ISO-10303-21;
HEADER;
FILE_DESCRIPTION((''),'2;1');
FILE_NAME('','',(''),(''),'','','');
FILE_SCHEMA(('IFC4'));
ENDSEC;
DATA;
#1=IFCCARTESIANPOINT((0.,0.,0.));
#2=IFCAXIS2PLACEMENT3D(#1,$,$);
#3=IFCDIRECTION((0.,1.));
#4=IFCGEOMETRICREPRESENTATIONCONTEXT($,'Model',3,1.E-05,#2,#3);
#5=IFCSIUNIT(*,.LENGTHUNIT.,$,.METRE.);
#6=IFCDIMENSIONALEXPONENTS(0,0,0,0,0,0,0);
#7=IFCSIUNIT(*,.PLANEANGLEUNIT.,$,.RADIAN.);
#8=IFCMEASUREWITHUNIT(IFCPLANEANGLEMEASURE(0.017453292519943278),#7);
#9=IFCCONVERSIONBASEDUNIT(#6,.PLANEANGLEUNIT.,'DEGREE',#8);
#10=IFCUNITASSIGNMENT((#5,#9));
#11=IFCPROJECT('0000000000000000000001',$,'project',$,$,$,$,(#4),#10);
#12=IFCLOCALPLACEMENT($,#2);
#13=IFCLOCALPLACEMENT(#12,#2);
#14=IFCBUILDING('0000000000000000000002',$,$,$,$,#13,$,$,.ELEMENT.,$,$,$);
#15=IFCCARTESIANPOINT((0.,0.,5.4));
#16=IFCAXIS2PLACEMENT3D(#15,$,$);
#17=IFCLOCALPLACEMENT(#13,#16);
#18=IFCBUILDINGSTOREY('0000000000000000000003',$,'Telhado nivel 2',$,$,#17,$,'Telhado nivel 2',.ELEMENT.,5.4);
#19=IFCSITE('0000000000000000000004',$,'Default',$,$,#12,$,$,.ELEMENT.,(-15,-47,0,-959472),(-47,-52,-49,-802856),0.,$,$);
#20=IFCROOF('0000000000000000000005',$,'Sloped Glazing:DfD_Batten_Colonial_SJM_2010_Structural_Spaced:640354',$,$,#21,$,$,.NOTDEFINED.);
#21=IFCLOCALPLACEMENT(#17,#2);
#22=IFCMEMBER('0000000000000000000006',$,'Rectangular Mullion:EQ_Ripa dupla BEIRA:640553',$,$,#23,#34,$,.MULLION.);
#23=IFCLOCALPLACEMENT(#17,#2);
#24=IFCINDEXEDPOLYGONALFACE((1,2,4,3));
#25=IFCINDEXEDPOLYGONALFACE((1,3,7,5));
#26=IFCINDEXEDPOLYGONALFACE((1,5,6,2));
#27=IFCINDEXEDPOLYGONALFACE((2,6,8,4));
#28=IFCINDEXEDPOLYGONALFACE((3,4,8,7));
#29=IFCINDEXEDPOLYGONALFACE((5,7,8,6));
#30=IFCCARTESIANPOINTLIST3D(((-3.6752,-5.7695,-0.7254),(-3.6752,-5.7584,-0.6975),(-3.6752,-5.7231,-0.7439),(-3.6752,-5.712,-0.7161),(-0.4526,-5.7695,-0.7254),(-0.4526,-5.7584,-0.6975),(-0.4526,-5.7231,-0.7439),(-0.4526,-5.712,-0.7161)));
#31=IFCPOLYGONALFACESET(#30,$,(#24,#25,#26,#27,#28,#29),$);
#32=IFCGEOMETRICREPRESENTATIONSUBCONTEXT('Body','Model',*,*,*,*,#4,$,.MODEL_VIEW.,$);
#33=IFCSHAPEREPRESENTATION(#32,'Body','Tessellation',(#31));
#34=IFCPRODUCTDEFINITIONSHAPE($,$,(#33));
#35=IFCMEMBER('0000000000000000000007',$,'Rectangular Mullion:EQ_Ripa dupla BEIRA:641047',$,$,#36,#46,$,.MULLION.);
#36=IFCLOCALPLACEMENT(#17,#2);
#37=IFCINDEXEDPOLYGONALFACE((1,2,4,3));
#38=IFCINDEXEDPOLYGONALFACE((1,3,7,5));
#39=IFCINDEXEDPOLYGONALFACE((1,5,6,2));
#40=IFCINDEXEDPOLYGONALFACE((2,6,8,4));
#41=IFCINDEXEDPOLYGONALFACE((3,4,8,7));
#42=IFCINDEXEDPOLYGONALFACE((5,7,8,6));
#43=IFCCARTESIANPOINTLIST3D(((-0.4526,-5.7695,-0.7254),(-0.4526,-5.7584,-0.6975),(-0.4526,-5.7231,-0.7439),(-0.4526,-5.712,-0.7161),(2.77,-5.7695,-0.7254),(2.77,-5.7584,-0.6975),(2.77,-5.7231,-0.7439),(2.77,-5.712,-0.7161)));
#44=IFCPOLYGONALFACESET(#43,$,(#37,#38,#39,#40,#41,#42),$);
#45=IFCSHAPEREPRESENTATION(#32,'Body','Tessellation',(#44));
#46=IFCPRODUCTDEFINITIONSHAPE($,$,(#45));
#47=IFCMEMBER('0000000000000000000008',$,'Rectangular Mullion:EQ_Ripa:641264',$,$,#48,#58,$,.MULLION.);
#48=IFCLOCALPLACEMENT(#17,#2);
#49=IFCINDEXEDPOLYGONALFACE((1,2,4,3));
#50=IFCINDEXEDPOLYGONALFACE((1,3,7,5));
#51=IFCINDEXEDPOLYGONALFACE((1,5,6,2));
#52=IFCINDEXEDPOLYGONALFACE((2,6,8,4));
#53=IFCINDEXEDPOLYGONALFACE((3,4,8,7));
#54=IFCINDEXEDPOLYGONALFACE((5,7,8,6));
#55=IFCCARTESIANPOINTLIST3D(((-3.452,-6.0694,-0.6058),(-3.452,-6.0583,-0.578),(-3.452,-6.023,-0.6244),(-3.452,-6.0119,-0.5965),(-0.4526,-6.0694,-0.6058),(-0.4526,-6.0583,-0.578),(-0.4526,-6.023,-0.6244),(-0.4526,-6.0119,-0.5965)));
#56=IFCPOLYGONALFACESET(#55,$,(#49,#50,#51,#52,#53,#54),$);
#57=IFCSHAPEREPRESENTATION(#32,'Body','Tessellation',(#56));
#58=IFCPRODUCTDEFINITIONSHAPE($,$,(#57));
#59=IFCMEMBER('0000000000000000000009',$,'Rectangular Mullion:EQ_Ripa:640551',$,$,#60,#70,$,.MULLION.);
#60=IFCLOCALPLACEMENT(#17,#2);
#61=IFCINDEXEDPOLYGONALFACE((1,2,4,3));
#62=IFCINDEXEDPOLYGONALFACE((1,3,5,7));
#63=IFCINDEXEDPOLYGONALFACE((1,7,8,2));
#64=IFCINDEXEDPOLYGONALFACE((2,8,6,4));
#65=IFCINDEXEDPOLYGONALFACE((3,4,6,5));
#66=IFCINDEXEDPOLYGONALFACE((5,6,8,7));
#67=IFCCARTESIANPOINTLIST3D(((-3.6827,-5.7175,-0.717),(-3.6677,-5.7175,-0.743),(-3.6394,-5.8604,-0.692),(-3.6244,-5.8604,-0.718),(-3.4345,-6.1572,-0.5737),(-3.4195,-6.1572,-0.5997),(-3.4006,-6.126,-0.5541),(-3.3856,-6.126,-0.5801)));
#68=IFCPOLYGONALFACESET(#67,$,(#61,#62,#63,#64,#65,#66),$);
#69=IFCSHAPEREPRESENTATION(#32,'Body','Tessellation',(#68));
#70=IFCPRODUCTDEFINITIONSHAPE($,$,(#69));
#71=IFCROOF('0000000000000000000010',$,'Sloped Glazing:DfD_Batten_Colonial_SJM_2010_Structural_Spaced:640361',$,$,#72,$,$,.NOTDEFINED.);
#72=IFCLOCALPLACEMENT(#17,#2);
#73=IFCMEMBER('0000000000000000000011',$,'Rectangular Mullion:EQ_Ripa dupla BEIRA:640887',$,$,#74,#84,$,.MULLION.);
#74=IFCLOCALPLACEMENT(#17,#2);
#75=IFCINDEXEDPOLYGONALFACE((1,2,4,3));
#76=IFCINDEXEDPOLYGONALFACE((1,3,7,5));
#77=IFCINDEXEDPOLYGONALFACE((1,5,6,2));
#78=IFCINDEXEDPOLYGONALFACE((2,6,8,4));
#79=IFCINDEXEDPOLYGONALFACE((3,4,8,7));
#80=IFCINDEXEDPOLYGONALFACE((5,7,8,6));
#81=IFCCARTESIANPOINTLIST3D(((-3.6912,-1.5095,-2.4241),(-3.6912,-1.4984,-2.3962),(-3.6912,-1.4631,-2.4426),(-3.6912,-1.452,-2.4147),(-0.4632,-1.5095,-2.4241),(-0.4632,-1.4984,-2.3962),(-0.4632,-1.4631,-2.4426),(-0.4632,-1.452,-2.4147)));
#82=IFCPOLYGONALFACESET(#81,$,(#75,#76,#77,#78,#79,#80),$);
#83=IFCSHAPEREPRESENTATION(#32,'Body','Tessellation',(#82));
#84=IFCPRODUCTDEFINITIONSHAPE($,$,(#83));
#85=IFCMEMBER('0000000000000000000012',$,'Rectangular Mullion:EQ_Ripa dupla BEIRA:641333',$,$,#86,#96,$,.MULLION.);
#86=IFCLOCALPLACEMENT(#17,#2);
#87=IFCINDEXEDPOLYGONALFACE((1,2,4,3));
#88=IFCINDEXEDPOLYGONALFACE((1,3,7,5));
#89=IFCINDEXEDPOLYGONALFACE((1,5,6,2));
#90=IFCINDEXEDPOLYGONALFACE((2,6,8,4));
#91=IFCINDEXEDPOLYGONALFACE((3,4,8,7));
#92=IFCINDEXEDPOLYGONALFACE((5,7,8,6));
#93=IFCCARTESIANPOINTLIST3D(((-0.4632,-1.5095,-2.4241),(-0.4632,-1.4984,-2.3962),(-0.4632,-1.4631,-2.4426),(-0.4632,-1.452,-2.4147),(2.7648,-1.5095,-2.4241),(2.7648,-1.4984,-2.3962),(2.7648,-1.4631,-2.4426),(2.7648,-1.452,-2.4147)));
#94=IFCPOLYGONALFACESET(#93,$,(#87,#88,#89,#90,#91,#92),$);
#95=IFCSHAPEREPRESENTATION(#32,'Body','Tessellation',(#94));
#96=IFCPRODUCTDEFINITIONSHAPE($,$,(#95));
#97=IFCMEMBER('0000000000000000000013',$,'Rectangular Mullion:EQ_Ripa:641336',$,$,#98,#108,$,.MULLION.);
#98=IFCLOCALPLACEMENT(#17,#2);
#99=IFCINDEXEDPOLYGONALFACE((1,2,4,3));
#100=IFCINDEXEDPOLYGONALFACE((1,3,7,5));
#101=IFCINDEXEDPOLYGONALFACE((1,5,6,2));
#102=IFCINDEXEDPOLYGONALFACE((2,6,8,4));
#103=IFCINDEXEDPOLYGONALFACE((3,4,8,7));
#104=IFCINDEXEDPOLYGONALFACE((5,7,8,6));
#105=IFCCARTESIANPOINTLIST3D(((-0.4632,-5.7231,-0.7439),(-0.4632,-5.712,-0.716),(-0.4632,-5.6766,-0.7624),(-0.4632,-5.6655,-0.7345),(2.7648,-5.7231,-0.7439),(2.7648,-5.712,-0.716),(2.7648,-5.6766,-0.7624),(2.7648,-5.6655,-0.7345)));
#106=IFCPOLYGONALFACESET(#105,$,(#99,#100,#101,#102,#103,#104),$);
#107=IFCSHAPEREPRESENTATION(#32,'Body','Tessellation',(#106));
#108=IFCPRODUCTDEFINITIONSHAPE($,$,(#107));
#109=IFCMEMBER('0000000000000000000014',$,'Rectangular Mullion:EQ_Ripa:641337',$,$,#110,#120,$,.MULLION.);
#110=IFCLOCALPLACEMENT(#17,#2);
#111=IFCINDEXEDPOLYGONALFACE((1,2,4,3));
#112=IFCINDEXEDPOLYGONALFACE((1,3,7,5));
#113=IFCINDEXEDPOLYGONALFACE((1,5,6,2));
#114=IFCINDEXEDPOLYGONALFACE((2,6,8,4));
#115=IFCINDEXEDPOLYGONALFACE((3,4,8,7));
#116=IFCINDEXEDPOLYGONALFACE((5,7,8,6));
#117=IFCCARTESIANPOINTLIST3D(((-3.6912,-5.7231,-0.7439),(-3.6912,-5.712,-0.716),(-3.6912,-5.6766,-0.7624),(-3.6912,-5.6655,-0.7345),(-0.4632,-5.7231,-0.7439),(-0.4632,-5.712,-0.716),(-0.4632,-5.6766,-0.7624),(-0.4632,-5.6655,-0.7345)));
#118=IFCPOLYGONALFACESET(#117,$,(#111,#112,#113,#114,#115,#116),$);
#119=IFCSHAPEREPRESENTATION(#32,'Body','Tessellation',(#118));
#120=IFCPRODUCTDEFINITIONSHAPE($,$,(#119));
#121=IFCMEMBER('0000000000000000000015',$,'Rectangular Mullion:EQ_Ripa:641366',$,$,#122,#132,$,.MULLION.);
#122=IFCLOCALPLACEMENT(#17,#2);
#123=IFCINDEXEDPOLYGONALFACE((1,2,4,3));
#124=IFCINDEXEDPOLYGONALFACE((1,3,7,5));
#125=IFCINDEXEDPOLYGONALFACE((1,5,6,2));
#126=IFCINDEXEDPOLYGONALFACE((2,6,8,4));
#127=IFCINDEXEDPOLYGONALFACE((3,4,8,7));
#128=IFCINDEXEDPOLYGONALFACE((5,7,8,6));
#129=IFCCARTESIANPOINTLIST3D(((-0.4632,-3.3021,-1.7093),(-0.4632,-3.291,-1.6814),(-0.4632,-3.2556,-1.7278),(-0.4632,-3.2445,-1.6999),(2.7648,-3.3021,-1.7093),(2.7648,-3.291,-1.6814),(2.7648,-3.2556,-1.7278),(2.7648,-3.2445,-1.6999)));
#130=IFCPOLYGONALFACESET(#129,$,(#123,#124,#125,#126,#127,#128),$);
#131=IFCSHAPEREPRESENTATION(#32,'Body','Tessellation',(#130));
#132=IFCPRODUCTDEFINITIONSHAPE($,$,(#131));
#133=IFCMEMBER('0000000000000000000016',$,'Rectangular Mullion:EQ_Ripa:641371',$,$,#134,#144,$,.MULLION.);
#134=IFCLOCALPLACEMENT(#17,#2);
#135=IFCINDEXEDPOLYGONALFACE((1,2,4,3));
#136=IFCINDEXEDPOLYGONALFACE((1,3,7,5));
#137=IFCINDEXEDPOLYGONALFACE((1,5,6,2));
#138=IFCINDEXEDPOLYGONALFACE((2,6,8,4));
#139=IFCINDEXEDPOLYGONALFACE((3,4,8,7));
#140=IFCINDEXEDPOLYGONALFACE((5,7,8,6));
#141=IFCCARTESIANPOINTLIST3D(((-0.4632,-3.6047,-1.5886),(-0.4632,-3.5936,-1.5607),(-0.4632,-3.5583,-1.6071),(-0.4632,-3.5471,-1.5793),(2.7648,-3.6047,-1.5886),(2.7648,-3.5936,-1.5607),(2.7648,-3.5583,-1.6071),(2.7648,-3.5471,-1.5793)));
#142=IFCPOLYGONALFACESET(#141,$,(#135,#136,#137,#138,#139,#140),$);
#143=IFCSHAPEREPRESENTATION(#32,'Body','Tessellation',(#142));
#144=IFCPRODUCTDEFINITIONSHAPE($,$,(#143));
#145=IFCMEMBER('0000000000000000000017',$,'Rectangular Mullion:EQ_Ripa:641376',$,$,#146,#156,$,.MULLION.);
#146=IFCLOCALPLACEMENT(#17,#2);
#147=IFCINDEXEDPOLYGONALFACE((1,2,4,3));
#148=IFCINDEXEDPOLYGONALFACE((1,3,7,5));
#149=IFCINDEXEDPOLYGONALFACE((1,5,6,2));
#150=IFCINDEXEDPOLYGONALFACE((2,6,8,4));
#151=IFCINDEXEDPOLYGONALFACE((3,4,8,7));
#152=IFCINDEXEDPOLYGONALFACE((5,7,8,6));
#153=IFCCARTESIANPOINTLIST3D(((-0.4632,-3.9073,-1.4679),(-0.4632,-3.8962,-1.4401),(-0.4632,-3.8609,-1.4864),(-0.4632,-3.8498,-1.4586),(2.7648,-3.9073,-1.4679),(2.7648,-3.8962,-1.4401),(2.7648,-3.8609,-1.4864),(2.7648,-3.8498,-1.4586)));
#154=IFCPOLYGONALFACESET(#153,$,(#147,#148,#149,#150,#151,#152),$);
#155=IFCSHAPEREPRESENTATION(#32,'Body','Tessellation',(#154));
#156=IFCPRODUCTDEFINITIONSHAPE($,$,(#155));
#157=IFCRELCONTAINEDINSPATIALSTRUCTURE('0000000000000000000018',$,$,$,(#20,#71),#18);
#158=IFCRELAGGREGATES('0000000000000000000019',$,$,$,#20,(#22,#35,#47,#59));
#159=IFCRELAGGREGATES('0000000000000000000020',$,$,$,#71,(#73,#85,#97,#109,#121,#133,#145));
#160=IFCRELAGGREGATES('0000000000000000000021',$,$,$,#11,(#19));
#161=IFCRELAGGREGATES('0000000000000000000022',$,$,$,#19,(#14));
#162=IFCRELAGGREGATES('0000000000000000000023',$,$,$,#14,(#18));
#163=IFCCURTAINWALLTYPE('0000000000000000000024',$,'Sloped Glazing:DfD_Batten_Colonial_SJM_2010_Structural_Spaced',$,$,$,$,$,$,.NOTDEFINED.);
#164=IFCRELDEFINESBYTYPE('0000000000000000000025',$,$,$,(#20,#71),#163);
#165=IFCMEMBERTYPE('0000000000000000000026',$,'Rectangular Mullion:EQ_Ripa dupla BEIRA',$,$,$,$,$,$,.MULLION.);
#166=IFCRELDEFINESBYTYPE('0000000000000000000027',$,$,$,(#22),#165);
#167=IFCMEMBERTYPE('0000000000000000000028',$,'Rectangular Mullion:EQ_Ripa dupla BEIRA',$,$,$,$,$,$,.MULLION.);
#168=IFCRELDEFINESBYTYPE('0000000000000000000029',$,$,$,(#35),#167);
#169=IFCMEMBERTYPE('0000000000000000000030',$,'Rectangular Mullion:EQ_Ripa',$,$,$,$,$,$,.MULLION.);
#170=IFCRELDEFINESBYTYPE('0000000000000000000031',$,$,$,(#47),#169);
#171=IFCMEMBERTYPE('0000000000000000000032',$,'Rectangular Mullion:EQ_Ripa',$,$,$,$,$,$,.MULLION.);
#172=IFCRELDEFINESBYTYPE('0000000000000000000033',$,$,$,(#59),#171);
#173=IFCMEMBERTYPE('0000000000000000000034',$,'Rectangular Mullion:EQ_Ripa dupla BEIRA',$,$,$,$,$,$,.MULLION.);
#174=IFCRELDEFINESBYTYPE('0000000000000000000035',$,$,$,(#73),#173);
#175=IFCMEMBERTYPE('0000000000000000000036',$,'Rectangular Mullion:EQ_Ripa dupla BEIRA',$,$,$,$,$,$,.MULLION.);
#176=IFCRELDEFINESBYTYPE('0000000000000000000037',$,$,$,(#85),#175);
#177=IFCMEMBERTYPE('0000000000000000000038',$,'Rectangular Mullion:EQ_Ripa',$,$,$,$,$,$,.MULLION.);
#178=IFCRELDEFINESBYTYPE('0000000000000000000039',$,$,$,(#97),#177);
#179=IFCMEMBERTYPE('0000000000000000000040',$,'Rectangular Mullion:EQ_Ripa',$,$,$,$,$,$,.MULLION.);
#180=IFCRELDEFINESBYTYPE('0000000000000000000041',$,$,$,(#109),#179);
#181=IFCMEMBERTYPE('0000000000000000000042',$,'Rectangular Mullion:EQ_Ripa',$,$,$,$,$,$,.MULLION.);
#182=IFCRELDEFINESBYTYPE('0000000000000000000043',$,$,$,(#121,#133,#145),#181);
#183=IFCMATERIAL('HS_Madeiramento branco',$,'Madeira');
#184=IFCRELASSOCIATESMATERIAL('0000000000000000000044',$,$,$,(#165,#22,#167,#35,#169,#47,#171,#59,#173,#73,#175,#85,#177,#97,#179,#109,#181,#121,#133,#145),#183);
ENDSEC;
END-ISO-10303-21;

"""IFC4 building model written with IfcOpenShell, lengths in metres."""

from ifc_helpers import new_model, entity, si_unit, converted_unit, direction, frame, origin, place, context, subcontext, project, spatial, indexed_curve, outline, extrude, source, transform, mapped, material, type_object, type_shapes, element, aggregate, save


model = new_model("IFC4")

# Units and contexts
model_context = context("Model", 3, precision=1e-05, world=origin(), true_north=direction((0.0, 1.0)))
body_context = subcontext(model_context, "Body", "Model", "MODEL_VIEW")
ifc_project = project(units=[si_unit("LENGTHUNIT", "METRE"), converted_unit("PLANEANGLEUNIT", "DEGREE", entity("IfcPlaneAngleMeasure", 0.017453292519943278), si_unit("PLANEANGLEUNIT", "RADIAN"), dimensions=[0, 0, 0, 0, 0, 0, 0])], contexts=[model_context])

# Site, building, storey
site_placement = place(None, origin())
site = spatial("IfcSite", under=ifc_project, at=site_placement, Name="Default", CompositionType="ELEMENT", RefLatitude=(-15, -47, 0, -959472), RefLongitude=(-47, -52, -49, -802856), RefElevation=0.0)
building_placement = place(site_placement, origin())
building = spatial("IfcBuilding", under=site, at=building_placement, CompositionType="ELEMENT")
storey_placement = place(building_placement, frame((0.0, 0.0, 5.4)))
storey = spatial("IfcBuildingStorey", under=building, at=storey_placement, Name="Telhado nivel 2", LongName="Telhado nivel 2", CompositionType="ELEMENT", Elevation=5.4)

# Roofs, members
curtain_wall_type = type_object("IfcCurtainWallType", Name="Sloped Glazing:DfD_Batten_Colonial_SJM_2010_Structural_Spaced", PredefinedType="NOTDEFINED")
roof_1_placement = place(storey_placement, frame((0.0, 0.0, -5.4)))
roof_1 = element("IfcRoof", 1, at=roof_1_placement, inside=storey, type_object=curtain_wall_type, Name="Sloped Glazing:DfD_Batten_Colonial_SJM_2010_Structural_Spaced:640354", PredefinedType="NOTDEFINED")
ifc_material = material(Name="HS_Madeiramento branco", Category="Madeira")
member_type_1 = type_object("IfcMemberType", Name="Rectangular Mullion:EQ_Ripa dupla BEIRA", PredefinedType="MULLION", material=ifc_material)
shared_shape_1 = source(origin(), body_context, "Body", "SweptSolid", [
    extrude(outline(indexed_curve([(-0.025, -0.015), (0.025, -0.015), (0.025, 0.015), (-0.025, 0.015), (-0.025, -0.015)], self_intersect=False)), frame((-0.025, 0.0, -3.2226), z_axis=(0.0, 0.0, 1.0), x_axis=(-1.0, 0.0, 0.0)), (0.0, 0.0, 1.0), 3.2226),
])
type_shapes(member_type_1, [shared_shape_1])
member_1_placement = place(roof_1_placement, frame((-3.6752, -5.7175, 4.67), z_axis=(-1.0, 0.0, 0.0), x_axis=(0.0, 0.928878, -0.370385)))
member_1 = element("IfcMember", 2, at=member_1_placement, type_object=member_type_1, material=ifc_material, Name="Rectangular Mullion:EQ_Ripa dupla BEIRA:640553", PredefinedType="MULLION", context=body_context, shape_type="MappedRepresentation", body=[
    mapped(shared_shape_1, transform((0.0, 0.0, 0.0), scale=1.0)),
])
member_type_2 = type_object("IfcMemberType", Name="Rectangular Mullion:EQ_Ripa dupla BEIRA", PredefinedType="MULLION", material=ifc_material)
shared_shape_2 = source(origin(), body_context, "Body", "SweptSolid", [
    extrude(outline(indexed_curve([(-0.025, -0.015), (0.025, -0.015), (0.025, 0.015), (-0.025, 0.015), (-0.025, -0.015)], self_intersect=False)), frame((-0.025, 0.0, -3.2226), z_axis=(0.0, 0.0, 1.0), x_axis=(-1.0, 0.0, 0.0)), (0.0, 0.0, 1.0), 3.2226),
])
type_shapes(member_type_2, [shared_shape_2])
member_2_placement = place(roof_1_placement, frame((-0.4526, -5.7175, 4.67), z_axis=(-1.0, 0.0, 0.0), x_axis=(0.0, 0.928878, -0.370385)))
member_2 = element("IfcMember", 3, at=member_2_placement, type_object=member_type_2, material=ifc_material, Name="Rectangular Mullion:EQ_Ripa dupla BEIRA:641047", PredefinedType="MULLION", context=body_context, shape_type="MappedRepresentation", body=[
    mapped(shared_shape_2, transform((0.0, 0.0, 0.0), scale=1.0)),
])
member_type_3 = type_object("IfcMemberType", Name="Rectangular Mullion:EQ_Ripa", PredefinedType="MULLION", material=ifc_material)
shared_shape_3 = source(origin(), body_context, "Body", "SweptSolid", [
    extrude(outline(indexed_curve([(-0.025, -0.015), (0.025, -0.015), (0.025, 0.015), (-0.025, 0.015), (-0.025, -0.015)], self_intersect=False)), frame((0.0, 0.0, -2.9994), z_axis=(0.0, 0.0, 1.0), x_axis=(-1.0, 0.0, 0.0)), (0.0, 0.0, 1.0), 2.9994),
])
type_shapes(member_type_3, [shared_shape_3])
member_3_placement = place(roof_1_placement, frame((-0.4526, -6.0407, 4.7988), z_axis=(1.0, 0.0, 0.0), x_axis=(0.0, -0.928878, 0.370385)))
member_3 = element("IfcMember", 4, at=member_3_placement, type_object=member_type_3, material=ifc_material, Name="Rectangular Mullion:EQ_Ripa:641264", PredefinedType="MULLION", context=body_context, shape_type="MappedRepresentation", body=[
    mapped(shared_shape_3, transform((0.0, 0.0, 0.0), scale=1.0)),
])
member_type_4 = type_object("IfcMemberType", Name="Rectangular Mullion:EQ_Ripa", PredefinedType="MULLION", material=ifc_material)
shared_shape_4 = source(origin(), body_context, "Body", "SweptSolid", [
    extrude(outline(indexed_curve([(-0.2969, -0.025), (0.2255, -0.025), (0.2255, 0.025), (-0.154, 0.025), (-0.2969, -0.025)], self_intersect=False)), frame((-0.025, -0.015, -0.2969), z_axis=(0.0, 1.0, 0.0), x_axis=(0.0, 0.0, -1.0)), (0.0, 0.0, 1.0), 0.03),
])
type_shapes(member_type_4, [shared_shape_4])
member_4_placement = place(roof_1_placement, frame((-3.6752, -5.7175, 4.67), z_axis=(-0.539965, 0.781825, -0.311749), x_axis=(0.67708, 0.623498, 0.390913)))
member_4 = element("IfcMember", 5, at=member_4_placement, type_object=member_type_4, material=ifc_material, Name="Rectangular Mullion:EQ_Ripa:640551", PredefinedType="MULLION", context=body_context, shape_type="MappedRepresentation", body=[
    mapped(shared_shape_4, transform((0.0, 0.0, 0.0), scale=1.0)),
])
aggregate(roof_1, [member_1, member_2, member_3, member_4])
roof_2_placement = place(storey_placement, frame((0.0, 0.0, -5.4)))
roof_2 = element("IfcRoof", 6, at=roof_2_placement, inside=storey, type_object=curtain_wall_type, Name="Sloped Glazing:DfD_Batten_Colonial_SJM_2010_Structural_Spaced:640361", PredefinedType="NOTDEFINED")
member_type_5 = type_object("IfcMemberType", Name="Rectangular Mullion:EQ_Ripa dupla BEIRA", PredefinedType="MULLION", material=ifc_material)
shared_shape_5 = source(origin(), body_context, "Body", "SweptSolid", [
    extrude(outline(indexed_curve([(-0.025, -0.015), (0.025, -0.015), (0.025, 0.015), (-0.025, 0.015), (-0.025, -0.015)], self_intersect=False)), frame((-0.025, 0.0, -3.228), z_axis=(0.0, 0.0, 1.0), x_axis=(-1.0, 0.0, 0.0)), (0.0, 0.0, 1.0), 3.228),
])
type_shapes(member_type_5, [shared_shape_5])
member_5_placement = place(roof_2_placement, frame((-3.6912, -1.4575, 2.9713), z_axis=(-1.0, 0.0, 0.0), x_axis=(0.0, 0.928874, -0.370395)))
member_5 = element("IfcMember", 7, at=member_5_placement, type_object=member_type_5, material=ifc_material, Name="Rectangular Mullion:EQ_Ripa dupla BEIRA:640887", PredefinedType="MULLION", context=body_context, shape_type="MappedRepresentation", body=[
    mapped(shared_shape_5, transform((0.0, 0.0, 0.0), scale=1.0)),
])
member_type_6 = type_object("IfcMemberType", Name="Rectangular Mullion:EQ_Ripa dupla BEIRA", PredefinedType="MULLION", material=ifc_material)
shared_shape_6 = source(origin(), body_context, "Body", "SweptSolid", [
    extrude(outline(indexed_curve([(-0.025, -0.015), (0.025, -0.015), (0.025, 0.015), (-0.025, 0.015), (-0.025, -0.015)], self_intersect=False)), frame((-0.025, 0.0, -3.228), z_axis=(0.0, 0.0, 1.0), x_axis=(-1.0, 0.0, 0.0)), (0.0, 0.0, 1.0), 3.228),
])
type_shapes(member_type_6, [shared_shape_6])
member_6_placement = place(roof_2_placement, frame((-0.4632, -1.4575, 2.9713), z_axis=(-1.0, 0.0, 0.0), x_axis=(0.0, 0.928874, -0.370395)))
member_6 = element("IfcMember", 8, at=member_6_placement, type_object=member_type_6, material=ifc_material, Name="Rectangular Mullion:EQ_Ripa dupla BEIRA:641333", PredefinedType="MULLION", context=body_context, shape_type="MappedRepresentation", body=[
    mapped(shared_shape_6, transform((0.0, 0.0, 0.0), scale=1.0)),
])
member_type_7 = type_object("IfcMemberType", Name="Rectangular Mullion:EQ_Ripa", PredefinedType="MULLION", material=ifc_material)
shared_shape_7 = source(origin(), body_context, "Body", "SweptSolid", [
    extrude(outline(indexed_curve([(-0.025, -0.015), (0.025, -0.015), (0.025, 0.015), (-0.025, 0.015), (-0.025, -0.015)], self_intersect=False)), frame((-0.025, 0.0, -3.228), z_axis=(0.0, 0.0, 1.0), x_axis=(-1.0, 0.0, 0.0)), (0.0, 0.0, 1.0), 3.228),
])
type_shapes(member_type_7, [shared_shape_7])
member_7_placement = place(roof_2_placement, frame((2.7648, -5.7175, 4.6701), z_axis=(1.0, 0.0, 0.0), x_axis=(0.0, -0.928874, 0.370395)))
member_7 = element("IfcMember", 9, at=member_7_placement, type_object=member_type_7, material=ifc_material, Name="Rectangular Mullion:EQ_Ripa:641336", PredefinedType="MULLION", context=body_context, shape_type="MappedRepresentation", body=[
    mapped(shared_shape_7, transform((0.0, 0.0, 0.0), scale=1.0)),
])
member_type_8 = type_object("IfcMemberType", Name="Rectangular Mullion:EQ_Ripa", PredefinedType="MULLION", material=ifc_material)
shared_shape_8 = source(origin(), body_context, "Body", "SweptSolid", [
    extrude(outline(indexed_curve([(-0.025, -0.015), (0.025, -0.015), (0.025, 0.015), (-0.025, 0.015), (-0.025, -0.015)], self_intersect=False)), frame((-0.025, 0.0, -3.228), z_axis=(0.0, 0.0, 1.0), x_axis=(-1.0, 0.0, 0.0)), (0.0, 0.0, 1.0), 3.228),
])
type_shapes(member_type_8, [shared_shape_8])
member_8_placement = place(roof_2_placement, frame((-0.4632, -5.7175, 4.6701), z_axis=(1.0, 0.0, 0.0), x_axis=(0.0, -0.928874, 0.370395)))
member_8 = element("IfcMember", 10, at=member_8_placement, type_object=member_type_8, material=ifc_material, Name="Rectangular Mullion:EQ_Ripa:641337", PredefinedType="MULLION", context=body_context, shape_type="MappedRepresentation", body=[
    mapped(shared_shape_8, transform((0.0, 0.0, 0.0), scale=1.0)),
])
member_type_9 = type_object("IfcMemberType", Name="Rectangular Mullion:EQ_Ripa", PredefinedType="MULLION", material=ifc_material)
shared_shape_9 = source(origin(), body_context, "Body", "SweptSolid", [
    extrude(outline(indexed_curve([(-0.025, -0.015), (0.025, -0.015), (0.025, 0.015), (-0.025, 0.015), (-0.025, -0.015)], self_intersect=False)), frame((0.0, 0.0, -3.228), z_axis=(0.0, 0.0, 1.0), x_axis=(-1.0, 0.0, 0.0)), (0.0, 0.0, 1.0), 3.228),
])
type_shapes(member_type_9, [shared_shape_9])
member_9_placement = place(roof_2_placement, frame((2.7648, -3.2733, 3.6954), z_axis=(1.0, 0.0, 0.0), x_axis=(0.0, -0.928874, 0.370395)))
member_9 = element("IfcMember", 11, at=member_9_placement, type_object=member_type_9, material=ifc_material, Name="Rectangular Mullion:EQ_Ripa:641366", PredefinedType="MULLION", context=body_context, shape_type="MappedRepresentation", body=[
    mapped(shared_shape_9, transform((0.0, 0.0, 0.0), scale=1.0)),
])
member_10_placement = place(roof_2_placement, frame((2.7648, -3.5759, 3.8161), z_axis=(1.0, 0.0, 0.0), x_axis=(0.0, -0.928874, 0.370395)))
member_10 = element("IfcMember", 12, at=member_10_placement, type_object=member_type_9, material=ifc_material, Name="Rectangular Mullion:EQ_Ripa:641371", PredefinedType="MULLION", context=body_context, shape_type="MappedRepresentation", body=[
    mapped(shared_shape_9, transform((0.0, 0.0, 0.0), scale=1.0)),
])
member_11_placement = place(roof_2_placement, frame((2.7648, -3.8785, 3.9367), z_axis=(1.0, 0.0, 0.0), x_axis=(0.0, -0.928874, 0.370395)))
member_11 = element("IfcMember", 13, at=member_11_placement, type_object=member_type_9, material=ifc_material, Name="Rectangular Mullion:EQ_Ripa:641376", PredefinedType="MULLION", context=body_context, shape_type="MappedRepresentation", body=[
    mapped(shared_shape_9, transform((0.0, 0.0, 0.0), scale=1.0)),
])
aggregate(roof_2, [member_5, member_6, member_7, member_8, member_9, member_10, member_11])

save(model, "model.ifc")
